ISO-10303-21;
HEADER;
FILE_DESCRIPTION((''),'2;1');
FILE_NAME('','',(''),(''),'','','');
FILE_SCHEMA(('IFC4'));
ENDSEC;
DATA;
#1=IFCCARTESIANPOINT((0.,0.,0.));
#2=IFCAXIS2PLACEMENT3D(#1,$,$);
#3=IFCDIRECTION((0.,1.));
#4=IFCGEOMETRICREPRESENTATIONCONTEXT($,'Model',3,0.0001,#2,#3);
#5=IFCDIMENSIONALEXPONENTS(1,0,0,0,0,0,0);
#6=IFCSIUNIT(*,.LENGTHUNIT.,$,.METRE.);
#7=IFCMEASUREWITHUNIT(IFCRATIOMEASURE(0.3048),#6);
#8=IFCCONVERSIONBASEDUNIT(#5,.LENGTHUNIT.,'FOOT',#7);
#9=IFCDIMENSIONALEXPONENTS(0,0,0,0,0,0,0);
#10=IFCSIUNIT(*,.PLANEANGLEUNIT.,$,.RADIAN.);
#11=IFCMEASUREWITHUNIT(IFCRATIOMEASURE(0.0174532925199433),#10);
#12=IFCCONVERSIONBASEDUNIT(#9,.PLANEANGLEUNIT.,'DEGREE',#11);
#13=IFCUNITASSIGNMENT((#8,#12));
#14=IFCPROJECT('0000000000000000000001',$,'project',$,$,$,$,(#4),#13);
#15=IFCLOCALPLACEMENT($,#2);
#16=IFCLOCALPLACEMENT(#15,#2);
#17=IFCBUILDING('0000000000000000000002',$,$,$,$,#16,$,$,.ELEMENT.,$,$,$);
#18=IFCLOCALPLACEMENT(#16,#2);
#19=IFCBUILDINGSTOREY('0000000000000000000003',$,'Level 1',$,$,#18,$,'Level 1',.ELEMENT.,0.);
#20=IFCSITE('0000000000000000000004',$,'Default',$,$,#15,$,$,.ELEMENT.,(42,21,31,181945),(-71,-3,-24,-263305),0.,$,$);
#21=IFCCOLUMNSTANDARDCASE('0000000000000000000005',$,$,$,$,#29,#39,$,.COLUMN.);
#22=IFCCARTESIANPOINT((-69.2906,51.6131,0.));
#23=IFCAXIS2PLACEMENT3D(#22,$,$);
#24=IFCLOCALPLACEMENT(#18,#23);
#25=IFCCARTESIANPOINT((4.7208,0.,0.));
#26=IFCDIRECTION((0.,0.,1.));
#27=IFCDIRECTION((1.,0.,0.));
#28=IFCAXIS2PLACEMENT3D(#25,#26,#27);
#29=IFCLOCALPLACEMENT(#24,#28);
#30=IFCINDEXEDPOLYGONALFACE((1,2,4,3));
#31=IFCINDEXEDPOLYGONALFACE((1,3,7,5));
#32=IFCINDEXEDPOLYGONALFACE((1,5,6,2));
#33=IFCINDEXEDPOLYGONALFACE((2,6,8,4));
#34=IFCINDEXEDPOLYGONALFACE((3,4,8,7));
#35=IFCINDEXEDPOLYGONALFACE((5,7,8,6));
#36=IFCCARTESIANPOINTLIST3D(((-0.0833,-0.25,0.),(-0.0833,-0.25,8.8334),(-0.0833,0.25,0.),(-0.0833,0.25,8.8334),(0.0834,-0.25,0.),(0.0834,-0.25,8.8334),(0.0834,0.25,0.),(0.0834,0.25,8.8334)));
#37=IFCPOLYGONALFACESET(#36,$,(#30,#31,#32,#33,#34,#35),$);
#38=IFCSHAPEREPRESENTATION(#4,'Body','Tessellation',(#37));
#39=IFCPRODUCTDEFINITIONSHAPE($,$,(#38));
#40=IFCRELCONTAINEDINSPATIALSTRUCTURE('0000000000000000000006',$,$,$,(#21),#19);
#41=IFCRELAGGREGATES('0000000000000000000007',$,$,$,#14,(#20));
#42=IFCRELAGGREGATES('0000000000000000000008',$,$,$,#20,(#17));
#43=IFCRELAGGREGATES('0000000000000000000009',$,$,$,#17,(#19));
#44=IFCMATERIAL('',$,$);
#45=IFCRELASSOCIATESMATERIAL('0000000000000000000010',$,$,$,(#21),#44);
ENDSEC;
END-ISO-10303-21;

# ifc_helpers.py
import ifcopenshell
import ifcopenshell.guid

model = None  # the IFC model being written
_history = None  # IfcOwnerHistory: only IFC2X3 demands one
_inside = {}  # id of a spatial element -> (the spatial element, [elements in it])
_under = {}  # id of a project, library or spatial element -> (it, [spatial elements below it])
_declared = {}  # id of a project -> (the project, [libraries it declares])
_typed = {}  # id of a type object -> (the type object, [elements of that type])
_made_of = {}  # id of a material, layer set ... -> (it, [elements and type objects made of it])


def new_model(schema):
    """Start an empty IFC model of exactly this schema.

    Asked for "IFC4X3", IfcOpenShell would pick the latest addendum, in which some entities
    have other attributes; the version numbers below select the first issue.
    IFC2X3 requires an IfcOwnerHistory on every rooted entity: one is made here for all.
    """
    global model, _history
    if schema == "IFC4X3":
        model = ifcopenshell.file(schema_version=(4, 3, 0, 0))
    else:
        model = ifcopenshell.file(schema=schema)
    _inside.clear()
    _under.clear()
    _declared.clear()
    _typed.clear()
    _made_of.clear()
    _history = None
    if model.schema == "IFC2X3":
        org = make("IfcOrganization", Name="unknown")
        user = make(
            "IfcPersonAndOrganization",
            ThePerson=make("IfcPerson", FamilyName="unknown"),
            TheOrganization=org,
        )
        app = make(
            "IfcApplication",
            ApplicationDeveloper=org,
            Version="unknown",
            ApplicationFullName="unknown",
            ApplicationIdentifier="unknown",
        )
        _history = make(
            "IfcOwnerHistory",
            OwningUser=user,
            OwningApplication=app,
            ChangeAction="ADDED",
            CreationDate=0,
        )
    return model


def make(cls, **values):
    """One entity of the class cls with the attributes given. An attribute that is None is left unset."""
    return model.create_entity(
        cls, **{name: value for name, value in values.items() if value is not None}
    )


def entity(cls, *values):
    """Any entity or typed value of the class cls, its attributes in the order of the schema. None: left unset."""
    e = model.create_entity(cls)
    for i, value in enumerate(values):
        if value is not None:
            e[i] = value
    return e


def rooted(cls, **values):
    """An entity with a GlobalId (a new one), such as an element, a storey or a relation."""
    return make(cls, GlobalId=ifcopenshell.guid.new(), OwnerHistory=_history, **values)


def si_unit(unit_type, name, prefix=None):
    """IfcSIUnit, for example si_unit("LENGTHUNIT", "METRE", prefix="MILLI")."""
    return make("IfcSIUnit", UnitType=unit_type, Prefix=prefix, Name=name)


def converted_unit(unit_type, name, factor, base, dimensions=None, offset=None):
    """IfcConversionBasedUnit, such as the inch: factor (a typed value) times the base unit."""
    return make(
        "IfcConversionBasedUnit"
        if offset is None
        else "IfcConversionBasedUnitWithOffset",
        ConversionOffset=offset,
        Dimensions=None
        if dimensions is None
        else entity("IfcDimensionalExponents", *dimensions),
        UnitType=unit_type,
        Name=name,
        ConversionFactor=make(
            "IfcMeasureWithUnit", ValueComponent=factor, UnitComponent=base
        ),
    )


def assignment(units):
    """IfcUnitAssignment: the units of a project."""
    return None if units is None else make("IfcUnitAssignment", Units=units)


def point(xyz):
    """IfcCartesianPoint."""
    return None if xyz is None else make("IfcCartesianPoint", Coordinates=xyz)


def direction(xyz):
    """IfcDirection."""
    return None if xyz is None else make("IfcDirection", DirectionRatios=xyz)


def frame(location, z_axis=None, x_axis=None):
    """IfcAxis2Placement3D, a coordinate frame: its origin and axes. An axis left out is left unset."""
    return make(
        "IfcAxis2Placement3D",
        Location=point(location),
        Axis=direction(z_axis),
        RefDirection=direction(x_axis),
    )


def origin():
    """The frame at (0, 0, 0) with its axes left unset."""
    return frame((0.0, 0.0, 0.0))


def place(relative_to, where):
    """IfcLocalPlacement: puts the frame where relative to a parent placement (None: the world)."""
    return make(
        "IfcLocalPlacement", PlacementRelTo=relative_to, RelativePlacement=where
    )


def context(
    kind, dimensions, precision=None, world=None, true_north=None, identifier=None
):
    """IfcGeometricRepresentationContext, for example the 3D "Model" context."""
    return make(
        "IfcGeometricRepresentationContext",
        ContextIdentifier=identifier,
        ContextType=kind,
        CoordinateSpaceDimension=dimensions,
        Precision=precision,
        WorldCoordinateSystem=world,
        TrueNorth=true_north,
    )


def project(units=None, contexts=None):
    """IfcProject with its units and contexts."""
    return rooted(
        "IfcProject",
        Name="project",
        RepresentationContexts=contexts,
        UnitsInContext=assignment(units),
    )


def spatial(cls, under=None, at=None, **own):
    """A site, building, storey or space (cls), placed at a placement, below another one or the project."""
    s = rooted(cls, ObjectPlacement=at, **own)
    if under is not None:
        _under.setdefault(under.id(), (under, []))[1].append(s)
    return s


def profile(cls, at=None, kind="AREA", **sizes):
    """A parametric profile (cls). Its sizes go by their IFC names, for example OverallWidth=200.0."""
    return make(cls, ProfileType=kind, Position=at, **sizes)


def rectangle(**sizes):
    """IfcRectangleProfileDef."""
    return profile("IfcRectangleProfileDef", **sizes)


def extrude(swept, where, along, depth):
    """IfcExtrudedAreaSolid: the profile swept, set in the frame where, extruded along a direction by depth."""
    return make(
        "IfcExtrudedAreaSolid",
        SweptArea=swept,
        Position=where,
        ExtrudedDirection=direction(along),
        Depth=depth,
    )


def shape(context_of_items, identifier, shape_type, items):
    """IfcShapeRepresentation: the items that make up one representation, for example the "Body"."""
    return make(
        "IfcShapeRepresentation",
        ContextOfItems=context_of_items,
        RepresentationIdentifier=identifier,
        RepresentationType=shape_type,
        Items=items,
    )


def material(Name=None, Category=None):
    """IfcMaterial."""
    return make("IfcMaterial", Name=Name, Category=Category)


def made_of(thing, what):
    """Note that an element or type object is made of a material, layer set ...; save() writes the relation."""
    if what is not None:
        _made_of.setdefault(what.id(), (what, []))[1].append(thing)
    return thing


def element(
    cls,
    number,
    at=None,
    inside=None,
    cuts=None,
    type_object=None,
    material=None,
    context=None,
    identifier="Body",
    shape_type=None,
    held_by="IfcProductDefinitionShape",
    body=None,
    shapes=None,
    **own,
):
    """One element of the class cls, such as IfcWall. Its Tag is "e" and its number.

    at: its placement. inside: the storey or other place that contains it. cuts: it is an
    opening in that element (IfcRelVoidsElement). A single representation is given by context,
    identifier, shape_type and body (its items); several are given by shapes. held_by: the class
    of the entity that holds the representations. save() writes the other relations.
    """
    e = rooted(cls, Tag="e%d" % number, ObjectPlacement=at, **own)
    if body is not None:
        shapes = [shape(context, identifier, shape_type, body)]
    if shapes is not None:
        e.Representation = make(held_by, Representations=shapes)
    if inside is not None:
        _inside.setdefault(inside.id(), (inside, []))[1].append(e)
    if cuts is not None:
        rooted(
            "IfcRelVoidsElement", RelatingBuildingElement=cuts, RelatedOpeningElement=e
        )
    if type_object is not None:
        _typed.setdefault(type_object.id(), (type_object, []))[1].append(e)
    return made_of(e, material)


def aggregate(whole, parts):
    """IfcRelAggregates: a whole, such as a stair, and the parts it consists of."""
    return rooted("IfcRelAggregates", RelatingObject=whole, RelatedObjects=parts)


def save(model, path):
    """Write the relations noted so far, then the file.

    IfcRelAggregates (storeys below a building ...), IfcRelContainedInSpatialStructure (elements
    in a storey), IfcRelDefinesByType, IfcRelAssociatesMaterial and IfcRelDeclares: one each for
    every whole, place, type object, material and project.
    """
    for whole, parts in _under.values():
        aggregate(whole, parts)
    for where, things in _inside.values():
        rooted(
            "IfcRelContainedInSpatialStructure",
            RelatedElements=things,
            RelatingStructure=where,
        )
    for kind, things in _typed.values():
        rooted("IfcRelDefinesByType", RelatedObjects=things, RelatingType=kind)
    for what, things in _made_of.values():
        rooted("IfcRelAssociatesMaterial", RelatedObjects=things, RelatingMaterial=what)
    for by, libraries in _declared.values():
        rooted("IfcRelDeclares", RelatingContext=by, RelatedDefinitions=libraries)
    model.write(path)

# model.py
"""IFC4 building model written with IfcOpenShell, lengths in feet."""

from ifc_helpers import new_model, entity, si_unit, converted_unit, direction, frame, origin, place, context, project, spatial, rectangle, extrude, material, element, save


model = new_model("IFC4")

# Units and contexts
model_context = context("Model", 3, precision=0.0001, world=origin(), true_north=direction((0.0, 1.0)))
ifc_project = project(units=[converted_unit("LENGTHUNIT", "FOOT", entity("IfcRatioMeasure", 0.3048), si_unit("LENGTHUNIT", "METRE"), dimensions=[1, 0, 0, 0, 0, 0, 0]), converted_unit("PLANEANGLEUNIT", "DEGREE", entity("IfcRatioMeasure", 0.0174532925199433), si_unit("PLANEANGLEUNIT", "RADIAN"), dimensions=[0, 0, 0, 0, 0, 0, 0])], contexts=[model_context])

# Site, building, storey
site_placement = place(None, origin())
site = spatial("IfcSite", under=ifc_project, at=site_placement, Name="Default", CompositionType="ELEMENT", RefLatitude=(42, 21, 31, 181945), RefLongitude=(-71, -3, -24, -263305), RefElevation=0.0)
building_placement = place(site_placement, origin())
building = spatial("IfcBuilding", under=site, at=building_placement, CompositionType="ELEMENT")
storey_placement = place(building_placement, origin())
storey = spatial("IfcBuildingStorey", under=building, at=storey_placement, Name="Level 1", LongName="Level 1", CompositionType="ELEMENT", Elevation=0.0)

# Column
ifc_material_1 = material(Name="")
placement_1 = place(storey_placement, frame((-69.2906, 51.6131, 0.0)))
for number, where, z_axis, x_axis in (
    (1, (4.7208, 0.0, 0.0), (0.0, 0.0, 1.0), (1.0, 0.0, 0.0)),
):
    element("IfcColumnStandardCase", number, at=place(placement_1, frame(where, z_axis=z_axis, x_axis=x_axis)), inside=storey, material=ifc_material_1, PredefinedType="COLUMN", context=model_context, shape_type="SweptSolid", body=[
        extrude(rectangle(XDim=0.1667, YDim=0.5), origin(), (0.0, 0.0, 1.0), 8.8334),
    ])

save(model, "model.ifc")
